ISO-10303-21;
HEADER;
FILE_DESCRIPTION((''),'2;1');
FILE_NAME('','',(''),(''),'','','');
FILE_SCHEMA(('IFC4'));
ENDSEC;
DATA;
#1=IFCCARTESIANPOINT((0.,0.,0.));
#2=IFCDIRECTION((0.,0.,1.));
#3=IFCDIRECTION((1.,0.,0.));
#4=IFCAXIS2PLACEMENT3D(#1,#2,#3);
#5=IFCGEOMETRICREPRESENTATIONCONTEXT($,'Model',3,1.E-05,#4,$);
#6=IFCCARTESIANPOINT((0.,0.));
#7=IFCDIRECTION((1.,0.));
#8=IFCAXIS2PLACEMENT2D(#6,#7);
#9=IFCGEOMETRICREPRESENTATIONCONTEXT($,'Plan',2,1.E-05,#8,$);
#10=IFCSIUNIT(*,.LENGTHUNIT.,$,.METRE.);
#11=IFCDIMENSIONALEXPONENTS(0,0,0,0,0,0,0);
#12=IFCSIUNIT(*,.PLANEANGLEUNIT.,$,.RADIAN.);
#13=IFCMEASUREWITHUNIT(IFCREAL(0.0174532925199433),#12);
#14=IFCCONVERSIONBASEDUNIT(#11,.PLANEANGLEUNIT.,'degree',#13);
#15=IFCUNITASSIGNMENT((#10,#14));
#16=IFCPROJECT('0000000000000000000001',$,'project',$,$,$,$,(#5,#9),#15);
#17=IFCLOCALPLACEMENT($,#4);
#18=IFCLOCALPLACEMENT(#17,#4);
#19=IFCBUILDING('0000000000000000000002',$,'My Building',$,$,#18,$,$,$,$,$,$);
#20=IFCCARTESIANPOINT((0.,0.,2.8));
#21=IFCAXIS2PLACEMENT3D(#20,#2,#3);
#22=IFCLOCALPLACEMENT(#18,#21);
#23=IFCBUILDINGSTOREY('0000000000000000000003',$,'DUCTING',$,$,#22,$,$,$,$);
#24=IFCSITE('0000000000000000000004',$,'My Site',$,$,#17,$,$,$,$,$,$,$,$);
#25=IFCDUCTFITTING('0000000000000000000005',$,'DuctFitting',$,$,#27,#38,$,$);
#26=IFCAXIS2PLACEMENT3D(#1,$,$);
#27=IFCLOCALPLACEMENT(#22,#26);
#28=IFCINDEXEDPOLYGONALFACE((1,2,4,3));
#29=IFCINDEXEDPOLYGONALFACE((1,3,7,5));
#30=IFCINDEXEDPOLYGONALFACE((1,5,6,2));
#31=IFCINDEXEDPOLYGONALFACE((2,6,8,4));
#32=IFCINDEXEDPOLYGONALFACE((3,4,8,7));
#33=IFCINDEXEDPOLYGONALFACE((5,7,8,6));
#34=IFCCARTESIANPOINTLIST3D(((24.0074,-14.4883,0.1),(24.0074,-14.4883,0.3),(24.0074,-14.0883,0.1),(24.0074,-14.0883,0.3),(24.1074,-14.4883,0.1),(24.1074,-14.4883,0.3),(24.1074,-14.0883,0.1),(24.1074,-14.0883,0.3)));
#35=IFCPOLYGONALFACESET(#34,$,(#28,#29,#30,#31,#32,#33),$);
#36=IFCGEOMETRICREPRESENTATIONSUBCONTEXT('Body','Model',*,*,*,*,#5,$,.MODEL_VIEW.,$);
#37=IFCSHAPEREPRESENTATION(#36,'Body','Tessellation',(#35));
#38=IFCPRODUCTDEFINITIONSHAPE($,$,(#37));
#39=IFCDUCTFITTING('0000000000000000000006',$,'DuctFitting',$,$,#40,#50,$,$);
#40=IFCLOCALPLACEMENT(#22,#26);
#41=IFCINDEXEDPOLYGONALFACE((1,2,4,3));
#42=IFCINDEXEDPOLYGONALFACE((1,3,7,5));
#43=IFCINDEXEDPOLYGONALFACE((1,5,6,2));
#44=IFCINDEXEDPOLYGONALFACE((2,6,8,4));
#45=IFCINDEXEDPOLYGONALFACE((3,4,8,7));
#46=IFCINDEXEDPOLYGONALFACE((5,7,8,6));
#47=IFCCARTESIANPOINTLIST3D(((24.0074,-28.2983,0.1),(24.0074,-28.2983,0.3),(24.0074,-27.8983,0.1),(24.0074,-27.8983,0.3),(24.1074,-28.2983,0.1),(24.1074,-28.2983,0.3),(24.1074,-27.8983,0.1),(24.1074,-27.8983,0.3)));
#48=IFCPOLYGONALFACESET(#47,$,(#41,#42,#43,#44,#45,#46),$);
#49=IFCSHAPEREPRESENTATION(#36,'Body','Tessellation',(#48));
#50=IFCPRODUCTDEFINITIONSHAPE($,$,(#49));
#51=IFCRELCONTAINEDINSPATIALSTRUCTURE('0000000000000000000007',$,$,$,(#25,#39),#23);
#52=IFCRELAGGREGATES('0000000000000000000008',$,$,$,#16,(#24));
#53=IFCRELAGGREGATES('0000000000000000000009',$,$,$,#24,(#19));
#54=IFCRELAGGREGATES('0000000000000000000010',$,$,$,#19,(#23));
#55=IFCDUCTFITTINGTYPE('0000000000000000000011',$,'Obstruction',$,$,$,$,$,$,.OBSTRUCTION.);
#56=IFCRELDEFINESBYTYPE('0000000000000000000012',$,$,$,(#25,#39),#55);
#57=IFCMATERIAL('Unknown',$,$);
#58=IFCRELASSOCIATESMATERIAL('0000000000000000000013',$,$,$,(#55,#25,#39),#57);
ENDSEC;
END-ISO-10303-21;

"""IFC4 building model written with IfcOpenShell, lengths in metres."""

from ifc_helpers import new_model, entity, si_unit, converted_unit, frame, origin_with_axes, origin_2d_with_axis, place, context, subcontext, project, spatial, rectangle, extrude, material, material_profile, profile_set, profile_usage, type_object, element, save


model = new_model("IFC4")

# Units and contexts
model_context = context("Model", 3, precision=1e-05, world=origin_with_axes())
plan_context = context("Plan", 2, precision=1e-05, world=origin_2d_with_axis())
body_context = subcontext(model_context, "Body", "Model", "MODEL_VIEW")
ifc_project = project(units=[si_unit("LENGTHUNIT", "METRE"), converted_unit("PLANEANGLEUNIT", "degree", entity("IfcReal", 0.0174532925199433), si_unit("PLANEANGLEUNIT", "RADIAN"), dimensions=[0, 0, 0, 0, 0, 0, 0])], contexts=[model_context, plan_context])

# Site, building, storey
site_placement = place(None, origin_with_axes())
site = spatial("IfcSite", under=ifc_project, at=site_placement, Name="My Site")
building_placement = place(site_placement, origin_with_axes())
building = spatial("IfcBuilding", under=site, at=building_placement, Name="My Building")
storey_placement = place(building_placement, frame((0.0, 0.0, 2.8), z_axis=(0.0, 0.0, 1.0), x_axis=(1.0, 0.0, 0.0)))
storey = spatial("IfcBuildingStorey", under=building, at=storey_placement, Name="DUCTING")

# Shared definitions
ifc_material = material(Name="Unknown")

# Duct fittings
ifc_material_profile_1 = material_profile(ifc_material, rectangle(XDim=0.4, YDim=0.2))
ifc_profile_set_1 = profile_set([ifc_material_profile_1])
duct_fitting_type_1 = type_object("IfcDuctFittingType", Name="Obstruction", PredefinedType="OBSTRUCTION", material=ifc_profile_set_1)
ifc_profile_usage_1 = profile_usage(ifc_profile_set_1, cardinal=5)
duct_fitting_1_placement = place(storey_placement, frame((24.0074, -14.2883, 0.2), z_axis=(1.0, 0.0, 0.0), x_axis=(0.0, 1.0, 0.0)))
element("IfcDuctFitting", 1, at=duct_fitting_1_placement, inside=storey, type_object=duct_fitting_type_1, material=ifc_profile_usage_1, Name="DuctFitting", context=body_context, shape_type="SweptSolid", body=[
    extrude(rectangle(XDim=0.4, YDim=0.2), origin_with_axes(), (0.0, 0.0, 1.0), 0.1),
])
ifc_profile_usage_2 = profile_usage(ifc_profile_set_1, cardinal=5)
duct_fitting_2_placement = place(storey_placement, frame((24.0074, -28.0983, 0.2), z_axis=(1.0, 0.0, 0.0), x_axis=(0.0, 1.0, 0.0)))
element("IfcDuctFitting", 2, at=duct_fitting_2_placement, inside=storey, type_object=duct_fitting_type_1, material=ifc_profile_usage_2, Name="DuctFitting", context=body_context, shape_type="SweptSolid", body=[
    extrude(rectangle(XDim=0.4, YDim=0.2), origin_with_axes(), (0.0, 0.0, 1.0), 0.1),
])

save(model, "model.ifc")
